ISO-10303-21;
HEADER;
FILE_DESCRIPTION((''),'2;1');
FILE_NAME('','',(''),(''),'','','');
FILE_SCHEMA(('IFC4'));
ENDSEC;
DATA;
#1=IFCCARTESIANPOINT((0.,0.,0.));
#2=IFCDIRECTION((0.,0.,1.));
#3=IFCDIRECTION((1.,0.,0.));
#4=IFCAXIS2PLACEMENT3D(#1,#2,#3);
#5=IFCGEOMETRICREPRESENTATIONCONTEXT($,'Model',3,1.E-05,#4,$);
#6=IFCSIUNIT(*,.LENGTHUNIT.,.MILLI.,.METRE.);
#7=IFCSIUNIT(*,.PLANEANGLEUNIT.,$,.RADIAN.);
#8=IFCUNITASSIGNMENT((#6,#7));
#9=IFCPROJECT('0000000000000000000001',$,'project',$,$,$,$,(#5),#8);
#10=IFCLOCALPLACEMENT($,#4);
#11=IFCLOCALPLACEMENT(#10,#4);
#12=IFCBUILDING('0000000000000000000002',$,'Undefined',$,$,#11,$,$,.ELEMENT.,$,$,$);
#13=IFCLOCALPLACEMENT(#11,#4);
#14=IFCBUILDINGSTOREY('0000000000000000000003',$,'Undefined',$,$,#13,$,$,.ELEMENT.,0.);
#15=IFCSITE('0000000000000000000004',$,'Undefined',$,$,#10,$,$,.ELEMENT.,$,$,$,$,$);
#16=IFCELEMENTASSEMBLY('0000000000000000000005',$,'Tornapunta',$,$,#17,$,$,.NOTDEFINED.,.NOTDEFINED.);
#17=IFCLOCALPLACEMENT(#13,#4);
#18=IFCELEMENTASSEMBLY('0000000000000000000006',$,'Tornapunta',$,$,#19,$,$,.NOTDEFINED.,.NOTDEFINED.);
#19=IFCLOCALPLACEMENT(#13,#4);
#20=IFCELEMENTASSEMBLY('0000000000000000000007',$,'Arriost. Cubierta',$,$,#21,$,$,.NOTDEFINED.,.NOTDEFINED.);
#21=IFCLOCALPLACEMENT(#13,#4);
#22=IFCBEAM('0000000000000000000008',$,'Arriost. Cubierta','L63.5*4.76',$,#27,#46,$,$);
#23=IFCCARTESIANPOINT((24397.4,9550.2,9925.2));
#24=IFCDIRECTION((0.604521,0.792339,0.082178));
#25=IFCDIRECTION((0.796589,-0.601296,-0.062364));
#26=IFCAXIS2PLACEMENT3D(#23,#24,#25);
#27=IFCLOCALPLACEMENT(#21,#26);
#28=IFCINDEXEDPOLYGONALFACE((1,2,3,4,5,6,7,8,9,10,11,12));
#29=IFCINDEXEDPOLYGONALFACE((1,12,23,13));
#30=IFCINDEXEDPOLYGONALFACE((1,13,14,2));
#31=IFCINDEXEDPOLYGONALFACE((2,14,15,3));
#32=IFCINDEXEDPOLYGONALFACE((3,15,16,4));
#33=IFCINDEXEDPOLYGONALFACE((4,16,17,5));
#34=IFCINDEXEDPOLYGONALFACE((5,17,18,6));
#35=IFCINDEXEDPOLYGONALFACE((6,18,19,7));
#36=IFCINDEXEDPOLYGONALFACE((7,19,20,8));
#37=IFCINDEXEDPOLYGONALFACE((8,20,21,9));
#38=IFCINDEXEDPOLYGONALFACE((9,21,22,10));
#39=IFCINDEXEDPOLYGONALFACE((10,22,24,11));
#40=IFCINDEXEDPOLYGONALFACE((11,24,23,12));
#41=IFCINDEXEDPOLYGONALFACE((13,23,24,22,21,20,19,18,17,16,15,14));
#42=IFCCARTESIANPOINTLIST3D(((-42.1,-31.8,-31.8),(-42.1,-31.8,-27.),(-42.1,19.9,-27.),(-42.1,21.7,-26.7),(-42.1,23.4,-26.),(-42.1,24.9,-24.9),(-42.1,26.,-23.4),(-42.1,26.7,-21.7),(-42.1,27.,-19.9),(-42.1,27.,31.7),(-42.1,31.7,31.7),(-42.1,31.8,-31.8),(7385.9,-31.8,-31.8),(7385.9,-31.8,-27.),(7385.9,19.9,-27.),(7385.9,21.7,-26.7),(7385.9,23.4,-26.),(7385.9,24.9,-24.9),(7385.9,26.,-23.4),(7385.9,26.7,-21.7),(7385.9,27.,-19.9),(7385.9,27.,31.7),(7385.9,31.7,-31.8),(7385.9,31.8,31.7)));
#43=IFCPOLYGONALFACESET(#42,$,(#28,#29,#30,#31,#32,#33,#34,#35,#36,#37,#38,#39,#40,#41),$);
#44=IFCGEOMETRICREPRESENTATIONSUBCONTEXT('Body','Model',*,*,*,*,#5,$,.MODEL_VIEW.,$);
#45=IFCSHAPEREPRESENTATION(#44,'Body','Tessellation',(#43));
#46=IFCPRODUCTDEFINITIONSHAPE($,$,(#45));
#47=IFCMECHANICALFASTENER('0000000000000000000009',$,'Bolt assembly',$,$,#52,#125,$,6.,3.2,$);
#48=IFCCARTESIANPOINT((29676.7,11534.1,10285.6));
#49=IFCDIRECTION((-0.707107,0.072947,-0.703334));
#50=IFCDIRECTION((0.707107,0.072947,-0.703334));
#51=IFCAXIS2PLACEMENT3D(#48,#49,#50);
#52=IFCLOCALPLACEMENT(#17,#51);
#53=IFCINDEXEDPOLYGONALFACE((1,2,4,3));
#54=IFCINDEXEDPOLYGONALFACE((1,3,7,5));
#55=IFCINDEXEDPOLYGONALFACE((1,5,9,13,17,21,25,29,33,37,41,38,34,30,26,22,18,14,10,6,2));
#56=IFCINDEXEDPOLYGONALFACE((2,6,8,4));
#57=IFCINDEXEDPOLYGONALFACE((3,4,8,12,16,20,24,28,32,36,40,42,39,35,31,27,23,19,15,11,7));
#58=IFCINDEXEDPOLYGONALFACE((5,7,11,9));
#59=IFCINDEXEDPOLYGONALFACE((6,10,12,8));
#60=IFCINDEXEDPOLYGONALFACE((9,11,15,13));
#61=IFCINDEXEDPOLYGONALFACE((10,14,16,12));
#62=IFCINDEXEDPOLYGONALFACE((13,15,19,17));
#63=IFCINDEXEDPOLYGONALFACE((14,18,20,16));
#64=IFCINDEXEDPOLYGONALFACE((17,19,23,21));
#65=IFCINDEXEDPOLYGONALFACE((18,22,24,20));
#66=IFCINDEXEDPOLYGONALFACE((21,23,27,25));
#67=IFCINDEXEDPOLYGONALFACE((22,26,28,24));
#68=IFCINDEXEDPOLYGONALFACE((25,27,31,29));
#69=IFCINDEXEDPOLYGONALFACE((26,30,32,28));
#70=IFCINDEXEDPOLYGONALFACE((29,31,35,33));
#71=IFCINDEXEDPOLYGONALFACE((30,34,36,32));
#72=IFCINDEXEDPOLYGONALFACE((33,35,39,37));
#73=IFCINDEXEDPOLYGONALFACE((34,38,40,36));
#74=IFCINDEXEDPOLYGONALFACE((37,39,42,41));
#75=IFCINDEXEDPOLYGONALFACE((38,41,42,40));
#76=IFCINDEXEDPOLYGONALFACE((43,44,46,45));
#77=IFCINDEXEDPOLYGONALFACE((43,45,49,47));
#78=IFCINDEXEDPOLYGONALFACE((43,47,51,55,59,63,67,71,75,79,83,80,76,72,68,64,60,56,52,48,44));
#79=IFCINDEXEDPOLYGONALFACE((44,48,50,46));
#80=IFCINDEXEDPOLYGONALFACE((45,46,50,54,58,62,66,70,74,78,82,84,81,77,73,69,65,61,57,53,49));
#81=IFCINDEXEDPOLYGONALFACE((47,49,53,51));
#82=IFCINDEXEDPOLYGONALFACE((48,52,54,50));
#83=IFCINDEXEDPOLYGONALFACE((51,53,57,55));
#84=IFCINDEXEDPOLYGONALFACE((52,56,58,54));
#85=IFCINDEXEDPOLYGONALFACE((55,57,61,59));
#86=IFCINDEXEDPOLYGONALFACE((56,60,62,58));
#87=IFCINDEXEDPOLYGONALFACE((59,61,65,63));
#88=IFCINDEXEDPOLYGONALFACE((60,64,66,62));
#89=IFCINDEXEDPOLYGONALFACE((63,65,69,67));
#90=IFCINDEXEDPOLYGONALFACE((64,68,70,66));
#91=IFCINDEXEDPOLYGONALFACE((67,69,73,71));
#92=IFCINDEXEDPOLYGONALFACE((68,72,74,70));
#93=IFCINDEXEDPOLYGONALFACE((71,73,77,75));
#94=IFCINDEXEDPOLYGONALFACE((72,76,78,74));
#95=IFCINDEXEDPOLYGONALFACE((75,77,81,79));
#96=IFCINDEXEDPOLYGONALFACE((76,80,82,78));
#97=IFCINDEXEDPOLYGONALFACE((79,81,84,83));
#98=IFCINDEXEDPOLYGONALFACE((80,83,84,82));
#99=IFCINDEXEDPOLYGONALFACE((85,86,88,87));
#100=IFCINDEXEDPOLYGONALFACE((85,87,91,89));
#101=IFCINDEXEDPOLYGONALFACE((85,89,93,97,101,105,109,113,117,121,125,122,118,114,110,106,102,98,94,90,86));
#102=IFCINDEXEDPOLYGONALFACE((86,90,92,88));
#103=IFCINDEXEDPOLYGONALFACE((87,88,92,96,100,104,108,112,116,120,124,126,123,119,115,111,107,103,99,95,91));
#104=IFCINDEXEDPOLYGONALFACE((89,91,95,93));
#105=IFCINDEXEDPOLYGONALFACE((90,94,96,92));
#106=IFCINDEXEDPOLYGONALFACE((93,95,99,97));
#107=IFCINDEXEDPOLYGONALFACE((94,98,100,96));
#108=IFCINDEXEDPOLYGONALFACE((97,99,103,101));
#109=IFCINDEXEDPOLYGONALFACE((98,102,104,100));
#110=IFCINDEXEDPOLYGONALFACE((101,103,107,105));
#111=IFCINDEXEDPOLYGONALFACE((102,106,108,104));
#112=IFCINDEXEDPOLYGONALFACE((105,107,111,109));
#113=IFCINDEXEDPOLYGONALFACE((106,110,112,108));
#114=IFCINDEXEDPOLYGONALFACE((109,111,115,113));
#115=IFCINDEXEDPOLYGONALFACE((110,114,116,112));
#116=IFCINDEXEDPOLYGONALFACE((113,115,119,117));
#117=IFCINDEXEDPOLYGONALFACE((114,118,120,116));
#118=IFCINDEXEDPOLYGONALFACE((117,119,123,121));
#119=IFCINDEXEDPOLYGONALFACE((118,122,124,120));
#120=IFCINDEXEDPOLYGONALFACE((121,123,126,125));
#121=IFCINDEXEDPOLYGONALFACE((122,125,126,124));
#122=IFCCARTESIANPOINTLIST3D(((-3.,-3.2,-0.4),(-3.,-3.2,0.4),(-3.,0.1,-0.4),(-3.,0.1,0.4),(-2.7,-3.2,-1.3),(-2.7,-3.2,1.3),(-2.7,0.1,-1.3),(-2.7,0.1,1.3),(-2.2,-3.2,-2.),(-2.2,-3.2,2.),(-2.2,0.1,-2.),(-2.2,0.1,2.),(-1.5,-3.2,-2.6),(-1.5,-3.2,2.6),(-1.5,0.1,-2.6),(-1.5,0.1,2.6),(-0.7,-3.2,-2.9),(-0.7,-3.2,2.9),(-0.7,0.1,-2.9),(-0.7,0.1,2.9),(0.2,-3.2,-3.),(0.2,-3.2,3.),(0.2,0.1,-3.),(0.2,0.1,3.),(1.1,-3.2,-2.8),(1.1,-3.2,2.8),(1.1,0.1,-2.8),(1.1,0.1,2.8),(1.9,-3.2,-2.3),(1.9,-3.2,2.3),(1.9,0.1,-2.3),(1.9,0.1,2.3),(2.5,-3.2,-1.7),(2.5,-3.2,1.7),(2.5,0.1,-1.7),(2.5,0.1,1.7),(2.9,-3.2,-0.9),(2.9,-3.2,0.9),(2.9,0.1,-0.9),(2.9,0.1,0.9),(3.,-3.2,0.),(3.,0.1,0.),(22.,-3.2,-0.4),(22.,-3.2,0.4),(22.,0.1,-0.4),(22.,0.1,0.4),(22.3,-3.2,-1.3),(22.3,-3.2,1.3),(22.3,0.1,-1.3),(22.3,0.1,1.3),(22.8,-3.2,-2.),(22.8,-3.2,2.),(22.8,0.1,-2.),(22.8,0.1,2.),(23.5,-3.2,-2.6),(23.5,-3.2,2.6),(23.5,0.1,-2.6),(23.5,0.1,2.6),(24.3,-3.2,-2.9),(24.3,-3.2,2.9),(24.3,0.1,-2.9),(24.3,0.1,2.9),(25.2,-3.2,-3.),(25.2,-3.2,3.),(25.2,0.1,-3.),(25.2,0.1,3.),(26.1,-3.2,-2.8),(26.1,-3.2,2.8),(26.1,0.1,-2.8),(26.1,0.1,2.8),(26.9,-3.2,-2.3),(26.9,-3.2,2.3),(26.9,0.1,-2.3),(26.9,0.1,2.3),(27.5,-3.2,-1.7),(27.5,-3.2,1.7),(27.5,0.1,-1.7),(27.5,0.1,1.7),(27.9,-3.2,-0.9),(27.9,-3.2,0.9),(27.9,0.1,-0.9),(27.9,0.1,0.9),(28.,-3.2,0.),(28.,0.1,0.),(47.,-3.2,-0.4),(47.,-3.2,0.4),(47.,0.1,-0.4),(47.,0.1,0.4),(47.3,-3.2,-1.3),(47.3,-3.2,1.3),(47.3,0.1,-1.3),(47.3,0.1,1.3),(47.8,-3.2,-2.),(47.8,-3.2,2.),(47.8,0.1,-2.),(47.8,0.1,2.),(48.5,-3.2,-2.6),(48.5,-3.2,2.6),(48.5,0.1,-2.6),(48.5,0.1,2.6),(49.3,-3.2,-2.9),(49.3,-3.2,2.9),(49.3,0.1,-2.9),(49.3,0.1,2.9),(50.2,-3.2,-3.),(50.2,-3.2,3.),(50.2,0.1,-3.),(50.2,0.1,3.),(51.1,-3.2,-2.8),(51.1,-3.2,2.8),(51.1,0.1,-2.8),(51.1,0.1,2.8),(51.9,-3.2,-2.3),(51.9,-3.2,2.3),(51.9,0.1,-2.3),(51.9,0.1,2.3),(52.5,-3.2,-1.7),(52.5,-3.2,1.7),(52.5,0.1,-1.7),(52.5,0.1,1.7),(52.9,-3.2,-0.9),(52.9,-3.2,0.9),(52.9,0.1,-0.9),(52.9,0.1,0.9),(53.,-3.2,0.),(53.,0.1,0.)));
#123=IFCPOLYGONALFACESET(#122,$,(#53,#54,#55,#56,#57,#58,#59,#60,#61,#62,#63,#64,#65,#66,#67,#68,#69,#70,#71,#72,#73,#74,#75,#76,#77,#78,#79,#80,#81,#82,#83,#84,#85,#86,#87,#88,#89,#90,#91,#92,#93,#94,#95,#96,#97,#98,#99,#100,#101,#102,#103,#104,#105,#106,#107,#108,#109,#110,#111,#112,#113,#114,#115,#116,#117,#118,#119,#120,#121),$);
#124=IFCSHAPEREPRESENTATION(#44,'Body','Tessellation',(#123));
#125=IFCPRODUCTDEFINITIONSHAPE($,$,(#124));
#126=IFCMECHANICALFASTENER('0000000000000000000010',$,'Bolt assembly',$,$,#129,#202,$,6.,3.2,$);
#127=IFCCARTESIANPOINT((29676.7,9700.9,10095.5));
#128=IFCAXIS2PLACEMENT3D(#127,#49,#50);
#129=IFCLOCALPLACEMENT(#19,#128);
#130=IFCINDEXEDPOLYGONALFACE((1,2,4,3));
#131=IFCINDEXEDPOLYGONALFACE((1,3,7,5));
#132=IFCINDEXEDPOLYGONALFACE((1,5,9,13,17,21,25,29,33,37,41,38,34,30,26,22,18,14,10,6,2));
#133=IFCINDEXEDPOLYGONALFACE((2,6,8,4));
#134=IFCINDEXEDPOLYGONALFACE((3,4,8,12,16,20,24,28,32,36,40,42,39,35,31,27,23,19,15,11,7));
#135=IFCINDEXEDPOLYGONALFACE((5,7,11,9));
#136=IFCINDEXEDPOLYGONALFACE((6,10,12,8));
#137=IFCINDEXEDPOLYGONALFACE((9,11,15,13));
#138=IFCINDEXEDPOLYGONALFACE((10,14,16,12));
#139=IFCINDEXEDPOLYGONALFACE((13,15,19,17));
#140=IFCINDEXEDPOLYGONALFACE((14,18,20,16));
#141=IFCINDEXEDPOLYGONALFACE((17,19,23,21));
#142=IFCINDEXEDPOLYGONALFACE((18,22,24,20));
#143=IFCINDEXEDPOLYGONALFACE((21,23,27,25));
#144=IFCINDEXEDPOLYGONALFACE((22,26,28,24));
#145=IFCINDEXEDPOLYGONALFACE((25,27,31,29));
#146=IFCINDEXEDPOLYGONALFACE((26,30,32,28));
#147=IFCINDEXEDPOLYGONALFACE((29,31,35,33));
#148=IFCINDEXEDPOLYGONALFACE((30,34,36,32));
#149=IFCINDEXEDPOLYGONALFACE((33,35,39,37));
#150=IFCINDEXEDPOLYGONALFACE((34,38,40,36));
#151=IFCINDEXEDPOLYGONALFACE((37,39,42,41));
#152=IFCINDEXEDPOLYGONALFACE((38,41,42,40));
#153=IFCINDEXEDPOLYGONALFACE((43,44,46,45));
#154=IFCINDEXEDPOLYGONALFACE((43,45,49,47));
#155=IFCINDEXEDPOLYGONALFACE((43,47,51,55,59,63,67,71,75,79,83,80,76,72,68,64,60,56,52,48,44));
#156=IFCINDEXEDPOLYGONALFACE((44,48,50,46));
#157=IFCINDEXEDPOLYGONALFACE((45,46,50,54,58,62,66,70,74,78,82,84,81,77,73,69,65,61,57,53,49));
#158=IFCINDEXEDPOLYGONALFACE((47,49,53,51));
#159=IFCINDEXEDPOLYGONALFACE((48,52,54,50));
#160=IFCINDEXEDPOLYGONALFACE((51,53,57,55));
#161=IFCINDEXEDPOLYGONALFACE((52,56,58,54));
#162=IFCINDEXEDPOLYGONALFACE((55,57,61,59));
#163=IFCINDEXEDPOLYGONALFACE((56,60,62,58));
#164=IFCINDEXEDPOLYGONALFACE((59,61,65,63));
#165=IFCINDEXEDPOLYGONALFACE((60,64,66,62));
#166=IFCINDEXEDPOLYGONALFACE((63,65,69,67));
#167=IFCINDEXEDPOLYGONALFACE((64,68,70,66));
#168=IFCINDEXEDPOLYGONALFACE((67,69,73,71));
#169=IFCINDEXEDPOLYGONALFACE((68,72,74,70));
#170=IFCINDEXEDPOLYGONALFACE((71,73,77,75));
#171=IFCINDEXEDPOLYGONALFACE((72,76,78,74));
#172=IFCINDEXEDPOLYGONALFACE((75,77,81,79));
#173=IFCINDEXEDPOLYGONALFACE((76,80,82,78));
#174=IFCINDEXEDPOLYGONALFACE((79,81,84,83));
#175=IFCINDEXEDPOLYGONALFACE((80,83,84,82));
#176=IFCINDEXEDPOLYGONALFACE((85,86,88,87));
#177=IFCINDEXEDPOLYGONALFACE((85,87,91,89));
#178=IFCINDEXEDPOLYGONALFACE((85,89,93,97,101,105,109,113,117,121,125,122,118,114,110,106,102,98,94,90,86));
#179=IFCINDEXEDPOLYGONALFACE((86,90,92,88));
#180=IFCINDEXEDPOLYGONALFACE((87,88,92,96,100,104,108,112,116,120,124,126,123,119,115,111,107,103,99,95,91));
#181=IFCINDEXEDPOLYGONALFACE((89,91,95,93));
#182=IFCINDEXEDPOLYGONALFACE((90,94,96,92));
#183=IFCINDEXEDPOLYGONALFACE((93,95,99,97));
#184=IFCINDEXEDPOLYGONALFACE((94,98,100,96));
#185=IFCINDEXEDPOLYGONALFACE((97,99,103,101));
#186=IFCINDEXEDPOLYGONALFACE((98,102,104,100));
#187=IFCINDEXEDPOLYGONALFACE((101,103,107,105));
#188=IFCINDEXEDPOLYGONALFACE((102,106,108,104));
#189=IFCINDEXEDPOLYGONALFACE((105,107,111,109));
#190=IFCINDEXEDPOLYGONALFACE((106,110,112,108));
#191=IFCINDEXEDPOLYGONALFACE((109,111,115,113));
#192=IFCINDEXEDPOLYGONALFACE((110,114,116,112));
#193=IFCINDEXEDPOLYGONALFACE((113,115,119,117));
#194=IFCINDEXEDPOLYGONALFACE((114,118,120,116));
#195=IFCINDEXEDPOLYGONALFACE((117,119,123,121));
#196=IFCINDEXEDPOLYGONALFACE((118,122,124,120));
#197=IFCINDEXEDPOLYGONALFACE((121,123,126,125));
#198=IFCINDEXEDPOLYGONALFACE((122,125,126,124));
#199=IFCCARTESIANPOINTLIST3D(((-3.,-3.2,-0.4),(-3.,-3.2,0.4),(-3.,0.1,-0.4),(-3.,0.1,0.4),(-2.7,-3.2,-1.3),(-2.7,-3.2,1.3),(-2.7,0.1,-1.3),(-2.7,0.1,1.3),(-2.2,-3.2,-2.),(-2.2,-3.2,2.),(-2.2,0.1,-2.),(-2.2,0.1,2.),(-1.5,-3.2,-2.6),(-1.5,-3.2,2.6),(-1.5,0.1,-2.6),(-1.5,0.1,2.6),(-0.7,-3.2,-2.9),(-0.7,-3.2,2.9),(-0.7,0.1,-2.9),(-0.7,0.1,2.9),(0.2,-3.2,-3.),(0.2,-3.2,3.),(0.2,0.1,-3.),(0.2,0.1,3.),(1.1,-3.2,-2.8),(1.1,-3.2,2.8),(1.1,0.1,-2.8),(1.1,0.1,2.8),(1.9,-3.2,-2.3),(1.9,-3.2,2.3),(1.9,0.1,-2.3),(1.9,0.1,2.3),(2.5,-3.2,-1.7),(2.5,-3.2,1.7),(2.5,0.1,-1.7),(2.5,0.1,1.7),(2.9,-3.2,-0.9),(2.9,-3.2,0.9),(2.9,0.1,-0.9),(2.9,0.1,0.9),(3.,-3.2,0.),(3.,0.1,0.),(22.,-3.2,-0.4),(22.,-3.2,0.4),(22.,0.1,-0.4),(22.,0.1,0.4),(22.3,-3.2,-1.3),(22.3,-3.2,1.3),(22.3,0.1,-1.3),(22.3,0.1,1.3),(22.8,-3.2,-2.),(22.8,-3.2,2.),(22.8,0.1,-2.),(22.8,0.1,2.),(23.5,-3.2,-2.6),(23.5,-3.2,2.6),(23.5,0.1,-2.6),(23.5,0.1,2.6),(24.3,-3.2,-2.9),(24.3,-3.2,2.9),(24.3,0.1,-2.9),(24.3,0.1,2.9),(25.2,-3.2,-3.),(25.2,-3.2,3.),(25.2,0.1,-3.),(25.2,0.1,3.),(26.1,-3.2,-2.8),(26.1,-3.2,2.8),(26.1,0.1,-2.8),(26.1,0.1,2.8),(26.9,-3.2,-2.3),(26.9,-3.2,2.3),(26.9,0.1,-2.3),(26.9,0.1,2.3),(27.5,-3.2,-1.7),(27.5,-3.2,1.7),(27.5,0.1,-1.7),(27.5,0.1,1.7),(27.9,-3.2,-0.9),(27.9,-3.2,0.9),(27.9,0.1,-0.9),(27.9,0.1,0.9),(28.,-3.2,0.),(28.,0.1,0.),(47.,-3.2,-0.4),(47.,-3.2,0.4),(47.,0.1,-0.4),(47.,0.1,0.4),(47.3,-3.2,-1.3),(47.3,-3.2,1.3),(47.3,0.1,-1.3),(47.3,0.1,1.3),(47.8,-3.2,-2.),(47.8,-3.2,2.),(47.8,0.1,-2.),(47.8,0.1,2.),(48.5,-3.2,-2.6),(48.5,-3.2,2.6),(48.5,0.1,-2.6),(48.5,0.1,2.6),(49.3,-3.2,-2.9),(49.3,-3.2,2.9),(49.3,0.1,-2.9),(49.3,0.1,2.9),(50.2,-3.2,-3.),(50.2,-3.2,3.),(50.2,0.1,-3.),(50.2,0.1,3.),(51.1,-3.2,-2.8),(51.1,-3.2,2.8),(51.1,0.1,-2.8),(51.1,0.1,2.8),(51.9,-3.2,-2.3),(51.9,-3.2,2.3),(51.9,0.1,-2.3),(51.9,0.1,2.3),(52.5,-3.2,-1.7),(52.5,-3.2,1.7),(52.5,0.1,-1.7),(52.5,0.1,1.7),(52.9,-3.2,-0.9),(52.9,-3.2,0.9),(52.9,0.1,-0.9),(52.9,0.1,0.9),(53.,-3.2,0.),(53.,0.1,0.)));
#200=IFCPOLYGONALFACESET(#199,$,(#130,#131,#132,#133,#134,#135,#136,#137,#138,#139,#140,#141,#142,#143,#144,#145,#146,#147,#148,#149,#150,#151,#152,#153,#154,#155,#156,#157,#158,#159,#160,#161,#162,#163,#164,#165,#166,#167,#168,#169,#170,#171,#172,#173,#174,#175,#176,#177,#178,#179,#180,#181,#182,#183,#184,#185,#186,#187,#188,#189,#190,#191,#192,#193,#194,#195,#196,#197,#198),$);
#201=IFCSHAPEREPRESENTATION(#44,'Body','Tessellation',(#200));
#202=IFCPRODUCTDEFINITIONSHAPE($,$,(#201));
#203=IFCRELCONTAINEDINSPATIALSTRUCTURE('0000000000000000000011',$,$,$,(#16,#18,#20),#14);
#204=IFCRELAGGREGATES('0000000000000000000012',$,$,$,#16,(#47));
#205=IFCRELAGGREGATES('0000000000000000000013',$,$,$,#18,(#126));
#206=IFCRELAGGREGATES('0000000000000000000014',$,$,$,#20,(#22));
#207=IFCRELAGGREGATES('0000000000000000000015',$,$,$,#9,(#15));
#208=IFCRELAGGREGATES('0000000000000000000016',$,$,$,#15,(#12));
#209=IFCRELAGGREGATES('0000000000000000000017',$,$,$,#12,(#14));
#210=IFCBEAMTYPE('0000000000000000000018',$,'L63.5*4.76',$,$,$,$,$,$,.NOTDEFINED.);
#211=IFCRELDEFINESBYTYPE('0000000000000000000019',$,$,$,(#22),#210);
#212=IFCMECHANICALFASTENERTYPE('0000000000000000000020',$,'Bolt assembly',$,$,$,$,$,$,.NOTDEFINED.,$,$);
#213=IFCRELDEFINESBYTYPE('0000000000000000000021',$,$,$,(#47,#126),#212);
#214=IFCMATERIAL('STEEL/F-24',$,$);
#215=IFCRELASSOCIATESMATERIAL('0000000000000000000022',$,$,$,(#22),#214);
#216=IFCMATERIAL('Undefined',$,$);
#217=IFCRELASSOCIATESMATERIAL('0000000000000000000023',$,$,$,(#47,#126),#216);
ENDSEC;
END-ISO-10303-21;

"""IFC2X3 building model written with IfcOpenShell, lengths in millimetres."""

from ifc_helpers import new_model, si_unit, frame, origin_with_axes, origin_2d_with_axis, place, context, subcontext, project, spatial, circle, l_section, extrude, clip, halfspace, source, transform, mapped, material, type_object, element, aggregate, save


model = new_model("IFC2X3")

# Units and contexts
model_context = context("Model", 3, precision=1e-05, world=origin_with_axes())
body_context = subcontext(model_context, "Body", "Model", "MODEL_VIEW")
ifc_project = project(units=[si_unit("LENGTHUNIT", "METRE", prefix="MILLI"), si_unit("PLANEANGLEUNIT", "RADIAN")], contexts=[model_context])

# Site, building, storey
site_placement = place(None, origin_with_axes())
site = spatial("IfcSite", under=ifc_project, at=site_placement, Name="Undefined", CompositionType="ELEMENT")
building_placement = place(site_placement, origin_with_axes())
building = spatial("IfcBuilding", under=site, at=building_placement, Name="Undefined", CompositionType="ELEMENT")
storey_placement = place(building_placement, origin_with_axes())
storey = spatial("IfcBuildingStorey", under=building, at=storey_placement, Name="Undefined", CompositionType="ELEMENT", Elevation=0.0)

# Element assemblies, beam
assembly_1_placement = place(storey_placement, origin_with_axes())
assembly_1 = element("IfcElementAssembly", 1, at=assembly_1_placement, inside=storey, Name="Tornapunta", AssemblyPlace="NOTDEFINED", PredefinedType="NOTDEFINED")
ifc_material_1 = material(Name="STEEL/F-24")
assembly_2_placement = place(storey_placement, origin_with_axes())
assembly_2 = element("IfcElementAssembly", 2, at=assembly_2_placement, inside=storey, Name="Tornapunta", AssemblyPlace="NOTDEFINED", PredefinedType="NOTDEFINED")
beam_type_1 = type_object("IfcBeamType", Name="L63.5*4.76", PredefinedType="NOTDEFINED")
assembly_3_placement = place(storey_placement, origin_with_axes())
assembly_3 = element("IfcElementAssembly", 3, at=assembly_3_placement, inside=storey, Name="Arriost. Cubierta", AssemblyPlace="NOTDEFINED", PredefinedType="NOTDEFINED")
beam_1_placement = place(assembly_3_placement, frame((24397.4, 9550.2, 9925.2), z_axis=(0.604521, 0.792339, 0.082178), x_axis=(0.796589, -0.601296, -0.062364)))
beam_1 = element("IfcBeam", 4, at=beam_1_placement, type_object=beam_type_1, material=ifc_material_1, Name="Arriost. Cubierta", Description="L63.5*4.76", context=body_context, shape_type="Clipping", body=[
    clip(clip(extrude(l_section(Depth=63.5, Width=63.5, Thickness=4.8, FilletRadius=7.1, at=origin_2d_with_axis()), frame((7455.4, 0.0, 0.0), z_axis=(-1.0, 0.0, 0.0), x_axis=(0.0, -1.0, 0.0)), (0.0, 0.0, 1.0), 7566.9), halfspace(frame((7385.9, 31.8, 0.0), z_axis=(-1.0, 0.0, 0.0), x_axis=(0.0, 0.0, 1.0)), True)), halfspace(frame((-42.1, 31.8, 0.0), z_axis=(1.0, 0.0, 0.0), x_axis=(0.0, 0.0, -1.0)), True)),
])

# Mechanical fasteners
ifc_material_2 = material(Name="Undefined")
mechanical_fastener_type = type_object("IfcMechanicalFastenerType", Name="Bolt assembly")
shared_shape_1 = source(origin_with_axes(), body_context, "Body", "SweptSolid", [
    extrude(circle(Radius=3.0, at=origin_2d_with_axis()), frame((0.0, -3.2, 0.0), z_axis=(0.0, 1.0, 0.0), x_axis=(1.0, 0.0, 0.0)), (0.0, 0.0, 1.0), 3.3),
])
mechanical_fastener_1_placement = place(assembly_1_placement, frame((29676.7, 11534.1, 10285.6), z_axis=(-0.707107, 0.072947, -0.703334), x_axis=(0.707107, 0.072947, -0.703334)))
mechanical_fastener_1 = element("IfcMechanicalFastener", 5, at=mechanical_fastener_1_placement, type_object=mechanical_fastener_type, material=ifc_material_2, Name="Bolt assembly", NominalDiameter=6.0, NominalLength=3.2, context=body_context, shape_type="MappedRepresentation", body=[
    mapped(shared_shape_1, transform((0.0, 0.0, 0.0))),
    mapped(shared_shape_1, transform((25.0, 0.0, 0.0))),
    mapped(shared_shape_1, transform((50.0, 0.0, 0.0))),
])
aggregate(assembly_1, [mechanical_fastener_1])
mechanical_fastener_2_placement = place(assembly_2_placement, frame((29676.7, 9700.9, 10095.5), z_axis=(-0.707107, 0.072947, -0.703334), x_axis=(0.707107, 0.072947, -0.703334)))
mechanical_fastener_2 = element("IfcMechanicalFastener", 6, at=mechanical_fastener_2_placement, type_object=mechanical_fastener_type, material=ifc_material_2, Name="Bolt assembly", NominalDiameter=6.0, NominalLength=3.2, context=body_context, shape_type="MappedRepresentation", body=[
    mapped(shared_shape_1, transform((0.0, 0.0, 0.0))),
    mapped(shared_shape_1, transform((25.0, 0.0, 0.0))),
    mapped(shared_shape_1, transform((50.0, 0.0, 0.0))),
])
aggregate(assembly_2, [mechanical_fastener_2])

aggregate(assembly_3, [beam_1])

save(model, "model.ifc")
